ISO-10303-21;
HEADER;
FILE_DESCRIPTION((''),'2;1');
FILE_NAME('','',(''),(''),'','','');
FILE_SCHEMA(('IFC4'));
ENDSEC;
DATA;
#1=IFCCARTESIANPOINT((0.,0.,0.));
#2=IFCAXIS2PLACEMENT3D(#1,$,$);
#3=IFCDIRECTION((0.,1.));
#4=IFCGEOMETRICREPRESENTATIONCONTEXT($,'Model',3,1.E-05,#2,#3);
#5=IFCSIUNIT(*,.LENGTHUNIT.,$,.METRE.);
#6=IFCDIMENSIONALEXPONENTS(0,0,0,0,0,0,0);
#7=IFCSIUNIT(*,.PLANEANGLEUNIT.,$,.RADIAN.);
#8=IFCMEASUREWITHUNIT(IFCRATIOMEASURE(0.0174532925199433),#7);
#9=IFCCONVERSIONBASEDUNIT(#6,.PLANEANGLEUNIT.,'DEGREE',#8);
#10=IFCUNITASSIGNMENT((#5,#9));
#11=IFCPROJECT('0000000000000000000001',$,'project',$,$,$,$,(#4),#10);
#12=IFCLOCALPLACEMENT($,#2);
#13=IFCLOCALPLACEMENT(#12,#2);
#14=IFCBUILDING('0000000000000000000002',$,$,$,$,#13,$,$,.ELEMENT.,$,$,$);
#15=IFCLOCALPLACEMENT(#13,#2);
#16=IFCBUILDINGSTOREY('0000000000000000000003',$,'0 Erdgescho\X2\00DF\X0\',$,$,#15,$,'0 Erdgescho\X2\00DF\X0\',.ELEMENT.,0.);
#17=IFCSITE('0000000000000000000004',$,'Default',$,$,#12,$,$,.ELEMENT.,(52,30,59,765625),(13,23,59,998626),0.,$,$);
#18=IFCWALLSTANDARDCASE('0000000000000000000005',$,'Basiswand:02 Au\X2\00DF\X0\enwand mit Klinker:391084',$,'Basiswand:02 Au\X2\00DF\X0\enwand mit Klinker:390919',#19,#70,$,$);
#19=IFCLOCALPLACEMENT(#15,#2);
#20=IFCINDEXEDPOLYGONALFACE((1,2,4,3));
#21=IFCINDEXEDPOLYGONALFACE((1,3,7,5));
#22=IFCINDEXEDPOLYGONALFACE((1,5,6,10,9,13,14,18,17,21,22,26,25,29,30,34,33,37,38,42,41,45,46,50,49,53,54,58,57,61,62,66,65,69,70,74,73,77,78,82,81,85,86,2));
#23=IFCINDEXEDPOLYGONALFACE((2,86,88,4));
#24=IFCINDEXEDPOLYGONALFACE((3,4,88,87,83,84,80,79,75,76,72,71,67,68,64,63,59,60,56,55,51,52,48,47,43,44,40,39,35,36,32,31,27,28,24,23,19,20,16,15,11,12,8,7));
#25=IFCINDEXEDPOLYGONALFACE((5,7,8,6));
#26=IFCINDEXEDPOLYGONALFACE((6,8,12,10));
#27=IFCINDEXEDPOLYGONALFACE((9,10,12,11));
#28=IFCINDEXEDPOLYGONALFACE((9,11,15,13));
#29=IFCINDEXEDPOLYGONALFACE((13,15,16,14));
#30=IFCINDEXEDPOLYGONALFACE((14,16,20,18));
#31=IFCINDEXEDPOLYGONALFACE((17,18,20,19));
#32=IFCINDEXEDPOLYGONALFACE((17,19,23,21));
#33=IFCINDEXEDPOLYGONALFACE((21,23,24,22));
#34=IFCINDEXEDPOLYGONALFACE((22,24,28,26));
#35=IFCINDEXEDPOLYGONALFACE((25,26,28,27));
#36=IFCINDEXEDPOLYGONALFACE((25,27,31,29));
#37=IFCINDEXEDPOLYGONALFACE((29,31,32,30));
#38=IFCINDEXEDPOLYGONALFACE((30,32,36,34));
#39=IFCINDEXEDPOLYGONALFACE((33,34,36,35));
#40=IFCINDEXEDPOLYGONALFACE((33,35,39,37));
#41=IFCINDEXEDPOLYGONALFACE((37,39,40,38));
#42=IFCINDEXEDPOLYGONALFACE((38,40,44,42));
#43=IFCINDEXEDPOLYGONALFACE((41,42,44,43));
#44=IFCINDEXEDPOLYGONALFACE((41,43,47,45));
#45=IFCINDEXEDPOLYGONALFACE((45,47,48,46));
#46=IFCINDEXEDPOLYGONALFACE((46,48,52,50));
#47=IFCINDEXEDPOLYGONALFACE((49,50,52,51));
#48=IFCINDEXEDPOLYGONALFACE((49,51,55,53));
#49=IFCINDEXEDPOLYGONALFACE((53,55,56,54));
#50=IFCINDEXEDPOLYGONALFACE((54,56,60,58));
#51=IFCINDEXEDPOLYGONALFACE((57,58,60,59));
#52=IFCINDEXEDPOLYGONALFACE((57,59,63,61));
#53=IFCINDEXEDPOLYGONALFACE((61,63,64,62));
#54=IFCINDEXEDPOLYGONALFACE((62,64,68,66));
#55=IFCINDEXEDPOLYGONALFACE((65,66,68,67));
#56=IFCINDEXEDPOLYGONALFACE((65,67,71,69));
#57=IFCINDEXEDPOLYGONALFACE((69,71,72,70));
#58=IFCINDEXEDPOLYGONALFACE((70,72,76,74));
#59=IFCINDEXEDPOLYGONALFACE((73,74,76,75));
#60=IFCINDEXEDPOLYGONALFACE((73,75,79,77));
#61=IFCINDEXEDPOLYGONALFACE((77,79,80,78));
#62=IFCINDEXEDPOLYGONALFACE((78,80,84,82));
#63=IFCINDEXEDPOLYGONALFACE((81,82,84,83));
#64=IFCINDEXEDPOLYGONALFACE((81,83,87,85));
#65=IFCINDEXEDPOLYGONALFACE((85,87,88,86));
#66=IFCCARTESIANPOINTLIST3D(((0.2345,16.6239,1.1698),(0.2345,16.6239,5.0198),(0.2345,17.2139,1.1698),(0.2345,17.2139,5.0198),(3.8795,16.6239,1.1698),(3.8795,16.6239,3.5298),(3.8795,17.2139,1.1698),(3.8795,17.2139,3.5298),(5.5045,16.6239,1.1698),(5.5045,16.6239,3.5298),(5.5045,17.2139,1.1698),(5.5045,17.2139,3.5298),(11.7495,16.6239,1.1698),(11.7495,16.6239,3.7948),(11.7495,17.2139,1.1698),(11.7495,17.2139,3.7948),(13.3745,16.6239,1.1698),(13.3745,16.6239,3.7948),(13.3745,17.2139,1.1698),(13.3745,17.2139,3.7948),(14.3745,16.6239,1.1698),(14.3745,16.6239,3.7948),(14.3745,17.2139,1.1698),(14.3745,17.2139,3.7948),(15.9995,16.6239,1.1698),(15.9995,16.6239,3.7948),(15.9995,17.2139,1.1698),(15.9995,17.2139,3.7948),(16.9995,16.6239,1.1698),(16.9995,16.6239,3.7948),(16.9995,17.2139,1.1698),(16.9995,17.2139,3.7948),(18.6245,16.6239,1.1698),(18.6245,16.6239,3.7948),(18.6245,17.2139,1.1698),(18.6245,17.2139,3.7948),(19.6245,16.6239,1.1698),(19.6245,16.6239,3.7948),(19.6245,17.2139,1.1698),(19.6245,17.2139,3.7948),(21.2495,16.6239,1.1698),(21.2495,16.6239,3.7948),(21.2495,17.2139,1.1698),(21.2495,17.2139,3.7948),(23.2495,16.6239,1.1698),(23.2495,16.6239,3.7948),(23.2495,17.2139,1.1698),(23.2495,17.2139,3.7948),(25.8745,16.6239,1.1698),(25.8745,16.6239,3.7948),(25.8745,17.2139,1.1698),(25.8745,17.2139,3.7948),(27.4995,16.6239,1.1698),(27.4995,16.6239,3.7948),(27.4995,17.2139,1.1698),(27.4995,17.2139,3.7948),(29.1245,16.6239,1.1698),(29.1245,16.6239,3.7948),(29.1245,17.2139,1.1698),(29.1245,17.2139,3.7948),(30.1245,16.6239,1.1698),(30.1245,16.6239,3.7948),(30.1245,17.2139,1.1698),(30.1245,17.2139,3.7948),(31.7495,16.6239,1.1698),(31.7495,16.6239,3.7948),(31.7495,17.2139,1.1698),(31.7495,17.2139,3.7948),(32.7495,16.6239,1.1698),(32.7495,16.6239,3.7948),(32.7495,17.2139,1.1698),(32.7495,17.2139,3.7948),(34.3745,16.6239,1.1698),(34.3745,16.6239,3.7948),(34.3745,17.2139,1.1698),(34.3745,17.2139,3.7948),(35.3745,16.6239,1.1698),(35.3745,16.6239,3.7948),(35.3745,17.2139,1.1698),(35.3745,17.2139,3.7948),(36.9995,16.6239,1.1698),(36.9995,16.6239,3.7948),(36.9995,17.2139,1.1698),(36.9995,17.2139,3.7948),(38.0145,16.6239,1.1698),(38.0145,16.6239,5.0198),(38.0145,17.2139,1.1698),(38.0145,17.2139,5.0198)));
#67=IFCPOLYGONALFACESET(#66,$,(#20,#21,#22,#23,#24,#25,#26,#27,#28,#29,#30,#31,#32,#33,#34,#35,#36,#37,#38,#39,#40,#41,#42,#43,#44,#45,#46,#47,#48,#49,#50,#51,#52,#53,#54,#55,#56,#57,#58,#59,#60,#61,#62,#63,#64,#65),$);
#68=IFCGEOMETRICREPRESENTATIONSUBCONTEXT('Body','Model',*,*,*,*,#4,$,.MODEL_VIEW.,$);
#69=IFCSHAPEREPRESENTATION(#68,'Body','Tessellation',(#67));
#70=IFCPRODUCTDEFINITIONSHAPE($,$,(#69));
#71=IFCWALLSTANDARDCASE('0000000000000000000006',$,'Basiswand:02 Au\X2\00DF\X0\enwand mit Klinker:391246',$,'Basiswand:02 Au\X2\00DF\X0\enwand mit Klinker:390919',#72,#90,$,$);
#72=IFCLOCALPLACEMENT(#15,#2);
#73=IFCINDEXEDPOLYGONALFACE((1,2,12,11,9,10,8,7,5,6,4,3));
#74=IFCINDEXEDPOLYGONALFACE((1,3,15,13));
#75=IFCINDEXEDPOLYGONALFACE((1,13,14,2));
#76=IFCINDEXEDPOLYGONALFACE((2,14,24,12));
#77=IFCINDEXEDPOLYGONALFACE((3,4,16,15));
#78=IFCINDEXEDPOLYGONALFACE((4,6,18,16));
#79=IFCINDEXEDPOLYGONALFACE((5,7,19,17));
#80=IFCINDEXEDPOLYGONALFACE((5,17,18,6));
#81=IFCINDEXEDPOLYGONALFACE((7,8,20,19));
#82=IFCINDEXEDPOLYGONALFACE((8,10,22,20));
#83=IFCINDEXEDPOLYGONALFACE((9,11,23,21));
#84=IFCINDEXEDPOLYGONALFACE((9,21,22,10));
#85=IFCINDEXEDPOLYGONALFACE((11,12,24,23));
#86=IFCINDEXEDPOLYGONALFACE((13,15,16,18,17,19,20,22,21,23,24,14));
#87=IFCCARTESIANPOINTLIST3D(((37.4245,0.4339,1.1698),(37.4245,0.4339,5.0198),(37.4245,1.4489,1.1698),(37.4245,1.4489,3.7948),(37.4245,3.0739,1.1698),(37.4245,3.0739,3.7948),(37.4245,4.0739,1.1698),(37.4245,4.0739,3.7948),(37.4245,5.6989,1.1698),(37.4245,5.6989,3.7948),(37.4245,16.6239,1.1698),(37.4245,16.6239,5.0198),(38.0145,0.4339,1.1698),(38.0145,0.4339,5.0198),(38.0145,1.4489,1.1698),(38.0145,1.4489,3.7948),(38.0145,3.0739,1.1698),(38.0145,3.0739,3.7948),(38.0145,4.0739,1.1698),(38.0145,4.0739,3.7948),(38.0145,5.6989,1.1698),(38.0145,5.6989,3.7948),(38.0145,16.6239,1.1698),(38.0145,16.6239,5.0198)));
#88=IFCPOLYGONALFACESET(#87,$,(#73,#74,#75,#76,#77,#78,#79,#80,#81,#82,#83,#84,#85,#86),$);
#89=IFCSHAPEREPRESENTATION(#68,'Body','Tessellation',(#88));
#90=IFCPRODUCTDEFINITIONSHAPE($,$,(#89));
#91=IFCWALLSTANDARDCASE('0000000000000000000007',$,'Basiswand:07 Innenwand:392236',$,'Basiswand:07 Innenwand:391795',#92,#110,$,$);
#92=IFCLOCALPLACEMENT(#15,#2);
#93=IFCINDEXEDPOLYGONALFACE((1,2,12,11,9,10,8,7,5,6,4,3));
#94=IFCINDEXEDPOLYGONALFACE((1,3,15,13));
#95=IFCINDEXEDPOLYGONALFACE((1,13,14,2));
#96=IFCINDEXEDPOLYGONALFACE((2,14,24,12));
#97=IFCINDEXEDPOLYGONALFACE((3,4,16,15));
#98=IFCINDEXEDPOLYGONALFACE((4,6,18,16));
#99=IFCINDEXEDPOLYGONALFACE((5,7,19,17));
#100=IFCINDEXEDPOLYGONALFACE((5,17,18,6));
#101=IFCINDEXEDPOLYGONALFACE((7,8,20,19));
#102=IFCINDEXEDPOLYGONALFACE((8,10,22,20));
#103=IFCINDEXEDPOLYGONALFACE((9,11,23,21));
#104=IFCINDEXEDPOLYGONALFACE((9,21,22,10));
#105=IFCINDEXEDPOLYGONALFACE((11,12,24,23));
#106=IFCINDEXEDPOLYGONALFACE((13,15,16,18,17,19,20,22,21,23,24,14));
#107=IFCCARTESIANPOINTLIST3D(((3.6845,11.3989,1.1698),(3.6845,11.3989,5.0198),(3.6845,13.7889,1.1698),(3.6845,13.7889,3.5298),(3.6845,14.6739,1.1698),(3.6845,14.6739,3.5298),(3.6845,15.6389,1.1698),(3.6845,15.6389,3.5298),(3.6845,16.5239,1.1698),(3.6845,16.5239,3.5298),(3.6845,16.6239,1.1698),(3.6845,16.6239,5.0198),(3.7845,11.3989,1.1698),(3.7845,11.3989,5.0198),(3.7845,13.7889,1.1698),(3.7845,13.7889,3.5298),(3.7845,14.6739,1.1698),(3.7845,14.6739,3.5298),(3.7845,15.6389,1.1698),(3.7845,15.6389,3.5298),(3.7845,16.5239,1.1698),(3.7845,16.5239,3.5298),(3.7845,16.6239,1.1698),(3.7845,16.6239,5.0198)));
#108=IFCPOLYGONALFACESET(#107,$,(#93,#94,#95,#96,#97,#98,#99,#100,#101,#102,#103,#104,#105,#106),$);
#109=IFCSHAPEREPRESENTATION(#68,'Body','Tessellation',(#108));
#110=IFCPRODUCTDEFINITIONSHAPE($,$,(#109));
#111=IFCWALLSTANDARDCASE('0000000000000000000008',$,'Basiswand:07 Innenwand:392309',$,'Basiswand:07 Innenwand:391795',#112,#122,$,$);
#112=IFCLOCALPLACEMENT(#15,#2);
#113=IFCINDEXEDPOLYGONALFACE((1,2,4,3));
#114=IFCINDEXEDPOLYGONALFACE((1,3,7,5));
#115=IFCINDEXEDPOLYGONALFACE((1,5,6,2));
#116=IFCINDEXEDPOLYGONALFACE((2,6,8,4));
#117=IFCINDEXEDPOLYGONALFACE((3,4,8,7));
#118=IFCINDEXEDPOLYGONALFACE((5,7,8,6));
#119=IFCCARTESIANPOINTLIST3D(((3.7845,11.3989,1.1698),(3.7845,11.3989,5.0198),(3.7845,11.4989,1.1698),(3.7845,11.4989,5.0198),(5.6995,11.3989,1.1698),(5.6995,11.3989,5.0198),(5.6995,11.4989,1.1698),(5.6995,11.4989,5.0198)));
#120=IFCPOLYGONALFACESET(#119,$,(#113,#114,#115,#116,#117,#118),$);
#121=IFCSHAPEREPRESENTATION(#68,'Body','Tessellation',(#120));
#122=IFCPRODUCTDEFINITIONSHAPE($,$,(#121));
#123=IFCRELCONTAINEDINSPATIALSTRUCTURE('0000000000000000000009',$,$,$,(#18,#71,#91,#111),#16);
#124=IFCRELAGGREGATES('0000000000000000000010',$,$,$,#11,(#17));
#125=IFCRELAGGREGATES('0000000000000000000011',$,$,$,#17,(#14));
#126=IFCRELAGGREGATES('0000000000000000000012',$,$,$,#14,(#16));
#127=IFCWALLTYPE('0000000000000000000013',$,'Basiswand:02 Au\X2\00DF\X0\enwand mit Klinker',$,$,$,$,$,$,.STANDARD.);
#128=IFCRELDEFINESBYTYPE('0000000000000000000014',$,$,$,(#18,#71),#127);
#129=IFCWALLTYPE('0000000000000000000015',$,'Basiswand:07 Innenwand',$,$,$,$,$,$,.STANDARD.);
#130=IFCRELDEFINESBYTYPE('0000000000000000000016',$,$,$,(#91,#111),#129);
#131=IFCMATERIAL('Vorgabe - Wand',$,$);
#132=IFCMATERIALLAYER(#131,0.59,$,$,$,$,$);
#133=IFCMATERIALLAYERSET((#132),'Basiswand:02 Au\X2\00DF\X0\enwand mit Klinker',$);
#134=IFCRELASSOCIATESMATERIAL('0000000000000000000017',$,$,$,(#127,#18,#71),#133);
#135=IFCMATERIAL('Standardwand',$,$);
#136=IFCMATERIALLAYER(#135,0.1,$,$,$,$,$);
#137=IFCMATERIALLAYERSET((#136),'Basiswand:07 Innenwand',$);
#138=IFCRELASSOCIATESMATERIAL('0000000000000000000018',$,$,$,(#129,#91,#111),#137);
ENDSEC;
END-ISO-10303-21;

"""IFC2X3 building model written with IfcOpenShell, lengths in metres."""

from ifc_helpers import new_model, entity, si_unit, converted_unit, direction, frame, frame_2d, origin, place, context, subcontext, project, spatial, polyline, rectangle, extrude, clip, bounded_halfspace, material, layer, layer_set, layer_usage, type_object, element, save


model = new_model("IFC2X3")

# Units and contexts
model_context = context("Model", 3, precision=1e-05, world=origin(), true_north=direction((0.0, 1.0)))
body_context = subcontext(model_context, "Body", "Model", "MODEL_VIEW")
ifc_project = project(units=[si_unit("LENGTHUNIT", "METRE"), converted_unit("PLANEANGLEUNIT", "DEGREE", entity("IfcRatioMeasure", 0.0174532925199433), si_unit("PLANEANGLEUNIT", "RADIAN"), dimensions=[0, 0, 0, 0, 0, 0, 0])], contexts=[model_context])

# Site, building, storey
site_placement = place(None, origin())
site = spatial("IfcSite", under=ifc_project, at=site_placement, Name="Default", CompositionType="ELEMENT", RefLatitude=(52, 30, 59, 765625), RefLongitude=(13, 23, 59, 998626), RefElevation=0.0)
building_placement = place(site_placement, origin())
building = spatial("IfcBuilding", under=site, at=building_placement, CompositionType="ELEMENT")
storey_placement = place(building_placement, origin())
storey = spatial("IfcBuildingStorey", under=building, at=storey_placement, Name="0 Erdgeschoß", LongName="0 Erdgeschoß", CompositionType="ELEMENT", Elevation=0.0)

# Walls, openings
ifc_material_1 = material(Name="Vorgabe - Wand")
ifc_layer_1 = layer(ifc_material_1, 0.59)
ifc_layer_set_1 = layer_set([ifc_layer_1], Name="Basiswand:02 Außenwand mit Klinker")
ifc_layer_usage_1 = layer_usage(ifc_layer_set_1, "AXIS2", "NEGATIVE", 0.295)
wall_type_1 = type_object("IfcWallType", Name="Basiswand:02 Außenwand mit Klinker", PredefinedType="STANDARD", material=ifc_layer_set_1)
wall_1_placement = place(storey_placement, frame((0.2345, 16.9189, 1.1698), z_axis=(0.0, 0.0, 1.0), x_axis=(1.0, 0.0, 0.0)))
wall_1 = element("IfcWallStandardCase", 1, at=wall_1_placement, inside=storey, type_object=wall_type_1, material=ifc_layer_usage_1, Name="Basiswand:02 Außenwand mit Klinker:391084", ObjectType="Basiswand:02 Außenwand mit Klinker:390919", context=body_context, shape_type="Clipping", body=[
    clip(extrude(rectangle(XDim=37.78, YDim=0.59, at=frame_2d((18.89, 0.0), x_axis=(-1.0, 0.0))), origin(), (0.0, 0.0, 1.0), 3.85), bounded_halfspace(frame((0.0, -0.295, 3.85), z_axis=(0.0, 0.0, -1.0), x_axis=(0.0, -1.0, 0.0)), True, frame((0.0, -0.295, 3.85)), polyline([(0.0, 0.0), (0.59, 0.0), (3.45, 0.0), (3.55, 0.0), (5.365, 0.0), (5.465, 0.0), (13.59, 0.0), (13.69, 0.0), (37.19, 0.0), (37.78, 0.0), (37.78, 0.59), (0.0, 0.59), (0.0, 0.0)]))),
])
opening_1_placement = place(wall_1_placement, frame((3.645, -0.295, 0.0)))
element("IfcOpeningElement", 2, at=opening_1_placement, cuts=wall_1, ObjectType="Opening", context=body_context, shape_type="SweptSolid", body=[
    extrude(rectangle(XDim=2.36, YDim=1.625, at=frame_2d((1.18, 0.8125), x_axis=(1.0, 0.0))), frame((0.0, 0.0, 0.0), z_axis=(0.0, 1.0, 0.0), x_axis=(0.0, 0.0, 1.0)), (0.0, 0.0, 1.0), 0.59),
])
opening_2_placement = place(wall_1_placement, frame((35.14, -0.295, 0.0)))
element("IfcOpeningElement", 3, at=opening_2_placement, cuts=wall_1, ObjectType="Opening", context=body_context, shape_type="SweptSolid", body=[
    extrude(rectangle(XDim=2.625, YDim=1.625, at=frame_2d((1.3125, 0.8125), x_axis=(1.0, 0.0))), frame((0.0, 0.0, 0.0), z_axis=(0.0, 1.0, 0.0), x_axis=(0.0, 0.0, 1.0)), (0.0, 0.0, 1.0), 0.59),
])
opening_3_placement = place(wall_1_placement, frame((11.515, -0.295, 0.0)))
element("IfcOpeningElement", 4, at=opening_3_placement, cuts=wall_1, ObjectType="Opening", context=body_context, shape_type="SweptSolid", body=[
    extrude(rectangle(XDim=2.625, YDim=1.625, at=frame_2d((1.3125, 0.8125), x_axis=(1.0, 0.0))), frame((0.0, 0.0, 0.0), z_axis=(0.0, 1.0, 0.0), x_axis=(0.0, 0.0, 1.0)), (0.0, 0.0, 1.0), 0.59),
])
opening_4_placement = place(wall_1_placement, frame((14.14, -0.295, 0.0)))
element("IfcOpeningElement", 5, at=opening_4_placement, cuts=wall_1, ObjectType="Opening", context=body_context, shape_type="SweptSolid", body=[
    extrude(rectangle(XDim=2.625, YDim=1.625, at=frame_2d((1.3125, 0.8125), x_axis=(1.0, 0.0))), frame((0.0, 0.0, 0.0), z_axis=(0.0, 1.0, 0.0), x_axis=(0.0, 0.0, 1.0)), (0.0, 0.0, 1.0), 0.59),
])
opening_5_placement = place(wall_1_placement, frame((16.765, -0.295, 0.0)))
element("IfcOpeningElement", 6, at=opening_5_placement, cuts=wall_1, ObjectType="Opening", context=body_context, shape_type="SweptSolid", body=[
    extrude(rectangle(XDim=2.625, YDim=1.625, at=frame_2d((1.3125, 0.8125), x_axis=(1.0, 0.0))), frame((0.0, 0.0, 0.0), z_axis=(0.0, 1.0, 0.0), x_axis=(0.0, 0.0, 1.0)), (0.0, 0.0, 1.0), 0.59),
])
opening_6_placement = place(wall_1_placement, frame((19.39, -0.295, 0.0)))
element("IfcOpeningElement", 7, at=opening_6_placement, cuts=wall_1, ObjectType="Opening", context=body_context, shape_type="SweptSolid", body=[
    extrude(rectangle(XDim=2.625, YDim=1.625, at=frame_2d((1.3125, 0.8125), x_axis=(1.0, 0.0))), frame((0.0, 0.0, 0.0), z_axis=(0.0, 1.0, 0.0), x_axis=(0.0, 0.0, 1.0)), (0.0, 0.0, 1.0), 0.59),
])
opening_7_placement = place(wall_1_placement, frame((27.265, -0.295, 0.0)))
element("IfcOpeningElement", 8, at=opening_7_placement, cuts=wall_1, ObjectType="Opening", context=body_context, shape_type="SweptSolid", body=[
    extrude(rectangle(XDim=2.625, YDim=1.625, at=frame_2d((1.3125, 0.8125), x_axis=(1.0, 0.0))), frame((0.0, 0.0, 0.0), z_axis=(0.0, 1.0, 0.0), x_axis=(0.0, 0.0, 1.0)), (0.0, 0.0, 1.0), 0.59),
])
opening_8_placement = place(wall_1_placement, frame((29.89, -0.295, 0.0)))
element("IfcOpeningElement", 9, at=opening_8_placement, cuts=wall_1, ObjectType="Opening", context=body_context, shape_type="SweptSolid", body=[
    extrude(rectangle(XDim=2.625, YDim=1.625, at=frame_2d((1.3125, 0.8125), x_axis=(1.0, 0.0))), frame((0.0, 0.0, 0.0), z_axis=(0.0, 1.0, 0.0), x_axis=(0.0, 0.0, 1.0)), (0.0, 0.0, 1.0), 0.59),
])
opening_9_placement = place(wall_1_placement, frame((32.515, -0.295, 0.0)))
element("IfcOpeningElement", 10, at=opening_9_placement, cuts=wall_1, ObjectType="Opening", context=body_context, shape_type="SweptSolid", body=[
    extrude(rectangle(XDim=2.625, YDim=1.625, at=frame_2d((1.3125, 0.8125), x_axis=(1.0, 0.0))), frame((0.0, 0.0, 0.0), z_axis=(0.0, 1.0, 0.0), x_axis=(0.0, 0.0, 1.0)), (0.0, 0.0, 1.0), 0.59),
])
opening_10_placement = place(wall_1_placement, frame((23.015, -0.295, 0.0)))
element("IfcOpeningElement", 11, at=opening_10_placement, cuts=wall_1, ObjectType="Opening", context=body_context, shape_type="SweptSolid", body=[
    extrude(rectangle(XDim=2.625, YDim=2.625, at=frame_2d((1.3125, 1.3125), x_axis=(1.0, 0.0))), frame((0.0, 0.0, 0.0), z_axis=(0.0, 1.0, 0.0), x_axis=(0.0, 0.0, 1.0)), (0.0, 0.0, 1.0), 0.59),
])
ifc_layer_usage_2 = layer_usage(ifc_layer_set_1, "AXIS2", "NEGATIVE", 0.295)
wall_2_placement = place(storey_placement, frame((37.7195, 16.6239, 1.1698), z_axis=(0.0, 0.0, 1.0), x_axis=(0.0, -1.0, 0.0)))
wall_2 = element("IfcWallStandardCase", 12, at=wall_2_placement, inside=storey, type_object=wall_type_1, material=ifc_layer_usage_2, Name="Basiswand:02 Außenwand mit Klinker:391246", ObjectType="Basiswand:02 Außenwand mit Klinker:390919", context=body_context, shape_type="Clipping", body=[
    clip(extrude(rectangle(XDim=16.19, YDim=0.59, at=frame_2d((8.095, 0.0), x_axis=(-1.0, 0.0))), origin(), (0.0, 0.0, 1.0), 3.85), bounded_halfspace(frame((0.0, -0.295, 3.85), z_axis=(0.0, 0.0, -1.0), x_axis=(1.0, 0.0, 0.0)), True, frame((0.0, -0.295, 3.85)), polyline([(0.0, 0.0), (15.6, 0.0), (16.19, 0.0), (16.19, 0.59), (0.0, 0.59), (0.0, 0.0)]))),
])
opening_11_placement = place(wall_2_placement, frame((10.925, -0.295, 0.0)))
element("IfcOpeningElement", 13, at=opening_11_placement, cuts=wall_2, ObjectType="Opening", context=body_context, shape_type="SweptSolid", body=[
    extrude(rectangle(XDim=2.625, YDim=1.625, at=frame_2d((1.3125, 0.8125), x_axis=(1.0, 0.0))), frame((0.0, 0.0, 0.0), z_axis=(0.0, 1.0, 0.0), x_axis=(0.0, 0.0, 1.0)), (0.0, 0.0, 1.0), 0.59),
])
opening_12_placement = place(wall_2_placement, frame((13.55, -0.295, 0.0)))
element("IfcOpeningElement", 14, at=opening_12_placement, cuts=wall_2, ObjectType="Opening", context=body_context, shape_type="SweptSolid", body=[
    extrude(rectangle(XDim=2.625, YDim=1.625, at=frame_2d((1.3125, 0.8125), x_axis=(1.0, 0.0))), frame((0.0, 0.0, 0.0), z_axis=(0.0, 1.0, 0.0), x_axis=(0.0, 0.0, 1.0)), (0.0, 0.0, 1.0), 0.59),
])
ifc_material_2 = material(Name="Standardwand")
ifc_layer_2 = layer(ifc_material_2, 0.1)
ifc_layer_set_2 = layer_set([ifc_layer_2], Name="Basiswand:07 Innenwand")
ifc_layer_usage_3 = layer_usage(ifc_layer_set_2, "AXIS2", "POSITIVE", -0.05)
wall_type_2 = type_object("IfcWallType", Name="Basiswand:07 Innenwand", PredefinedType="STANDARD", material=ifc_layer_set_2)
wall_3_placement = place(storey_placement, frame((3.7345, 16.6239, 1.1698), z_axis=(0.0, 0.0, 1.0), x_axis=(0.0, -1.0, 0.0)))
wall_3 = element("IfcWallStandardCase", 15, at=wall_3_placement, inside=storey, type_object=wall_type_2, material=ifc_layer_usage_3, Name="Basiswand:07 Innenwand:392236", ObjectType="Basiswand:07 Innenwand:391795", context=body_context, shape_type="Clipping", body=[
    clip(extrude(rectangle(XDim=5.225, YDim=0.1, at=frame_2d((2.6125, 0.0), x_axis=(-1.0, 0.0))), origin(), (0.0, 0.0, 1.0), 3.85), bounded_halfspace(frame((0.0, -0.05, 3.85), z_axis=(0.0, 0.0, -1.0), x_axis=(1.0, 0.0, 0.0)), True, frame((0.0, -0.05, 3.85)), polyline([(0.0, 0.0), (1.75, 0.0), (1.85, 0.0), (3.6, 0.0), (3.7, 0.0), (5.225, 0.0), (5.225, 0.1), (5.125, 0.1), (3.1, 0.1), (3.0, 0.1), (0.0, 0.1), (0.0, 0.0)]))),
])
opening_13_placement = place(wall_3_placement, frame((0.985, 0.05, 0.0)))
element("IfcOpeningElement", 16, at=opening_13_placement, cuts=wall_3, ObjectType="Opening", context=body_context, shape_type="SweptSolid", body=[
    extrude(rectangle(XDim=2.36, YDim=0.885, at=frame_2d((1.18, 0.4425), x_axis=(1.0, 0.0))), frame((0.0, 0.0, 0.0), z_axis=(0.0, -1.0, 0.0), x_axis=(0.0, 0.0, 1.0)), (0.0, 0.0, 1.0), 0.1),
])
opening_14_placement = place(wall_3_placement, frame((2.835, 0.05, 0.0)))
element("IfcOpeningElement", 17, at=opening_14_placement, cuts=wall_3, ObjectType="Opening", context=body_context, shape_type="SweptSolid", body=[
    extrude(rectangle(XDim=2.36, YDim=0.885, at=frame_2d((1.18, 0.4425), x_axis=(1.0, 0.0))), frame((0.0, 0.0, 0.0), z_axis=(0.0, -1.0, 0.0), x_axis=(0.0, 0.0, 1.0)), (0.0, 0.0, 1.0), 0.1),
])

# Wall
ifc_layer_usage_4 = layer_usage(ifc_layer_set_2, "AXIS2", "POSITIVE", -0.05)
wall_4_placement = place(storey_placement, frame((3.7845, 11.4489, 1.1698), z_axis=(0.0, 0.0, 1.0), x_axis=(1.0, 0.0, 0.0)))
element("IfcWallStandardCase", 18, at=wall_4_placement, inside=storey, type_object=wall_type_2, material=ifc_layer_usage_4, Name="Basiswand:07 Innenwand:392309", ObjectType="Basiswand:07 Innenwand:391795", context=body_context, shape_type="Clipping", body=[
    clip(extrude(rectangle(XDim=1.915, YDim=0.1, at=frame_2d((0.9575, 0.0), x_axis=(-1.0, 0.0))), origin(), (0.0, 0.0, 1.0), 3.85), bounded_halfspace(frame((0.0, -0.05, 3.85), z_axis=(0.0, 0.0, -1.0), x_axis=(0.0, -1.0, 0.0)), True, frame((0.0, -0.05, 3.85)), polyline([(0.0, 0.0), (1.815, 0.0), (1.915, 0.0), (1.915, 0.1), (1.815, 0.1), (0.0, 0.1), (0.0, 0.0)]))),
])

save(model, "model.ifc")
